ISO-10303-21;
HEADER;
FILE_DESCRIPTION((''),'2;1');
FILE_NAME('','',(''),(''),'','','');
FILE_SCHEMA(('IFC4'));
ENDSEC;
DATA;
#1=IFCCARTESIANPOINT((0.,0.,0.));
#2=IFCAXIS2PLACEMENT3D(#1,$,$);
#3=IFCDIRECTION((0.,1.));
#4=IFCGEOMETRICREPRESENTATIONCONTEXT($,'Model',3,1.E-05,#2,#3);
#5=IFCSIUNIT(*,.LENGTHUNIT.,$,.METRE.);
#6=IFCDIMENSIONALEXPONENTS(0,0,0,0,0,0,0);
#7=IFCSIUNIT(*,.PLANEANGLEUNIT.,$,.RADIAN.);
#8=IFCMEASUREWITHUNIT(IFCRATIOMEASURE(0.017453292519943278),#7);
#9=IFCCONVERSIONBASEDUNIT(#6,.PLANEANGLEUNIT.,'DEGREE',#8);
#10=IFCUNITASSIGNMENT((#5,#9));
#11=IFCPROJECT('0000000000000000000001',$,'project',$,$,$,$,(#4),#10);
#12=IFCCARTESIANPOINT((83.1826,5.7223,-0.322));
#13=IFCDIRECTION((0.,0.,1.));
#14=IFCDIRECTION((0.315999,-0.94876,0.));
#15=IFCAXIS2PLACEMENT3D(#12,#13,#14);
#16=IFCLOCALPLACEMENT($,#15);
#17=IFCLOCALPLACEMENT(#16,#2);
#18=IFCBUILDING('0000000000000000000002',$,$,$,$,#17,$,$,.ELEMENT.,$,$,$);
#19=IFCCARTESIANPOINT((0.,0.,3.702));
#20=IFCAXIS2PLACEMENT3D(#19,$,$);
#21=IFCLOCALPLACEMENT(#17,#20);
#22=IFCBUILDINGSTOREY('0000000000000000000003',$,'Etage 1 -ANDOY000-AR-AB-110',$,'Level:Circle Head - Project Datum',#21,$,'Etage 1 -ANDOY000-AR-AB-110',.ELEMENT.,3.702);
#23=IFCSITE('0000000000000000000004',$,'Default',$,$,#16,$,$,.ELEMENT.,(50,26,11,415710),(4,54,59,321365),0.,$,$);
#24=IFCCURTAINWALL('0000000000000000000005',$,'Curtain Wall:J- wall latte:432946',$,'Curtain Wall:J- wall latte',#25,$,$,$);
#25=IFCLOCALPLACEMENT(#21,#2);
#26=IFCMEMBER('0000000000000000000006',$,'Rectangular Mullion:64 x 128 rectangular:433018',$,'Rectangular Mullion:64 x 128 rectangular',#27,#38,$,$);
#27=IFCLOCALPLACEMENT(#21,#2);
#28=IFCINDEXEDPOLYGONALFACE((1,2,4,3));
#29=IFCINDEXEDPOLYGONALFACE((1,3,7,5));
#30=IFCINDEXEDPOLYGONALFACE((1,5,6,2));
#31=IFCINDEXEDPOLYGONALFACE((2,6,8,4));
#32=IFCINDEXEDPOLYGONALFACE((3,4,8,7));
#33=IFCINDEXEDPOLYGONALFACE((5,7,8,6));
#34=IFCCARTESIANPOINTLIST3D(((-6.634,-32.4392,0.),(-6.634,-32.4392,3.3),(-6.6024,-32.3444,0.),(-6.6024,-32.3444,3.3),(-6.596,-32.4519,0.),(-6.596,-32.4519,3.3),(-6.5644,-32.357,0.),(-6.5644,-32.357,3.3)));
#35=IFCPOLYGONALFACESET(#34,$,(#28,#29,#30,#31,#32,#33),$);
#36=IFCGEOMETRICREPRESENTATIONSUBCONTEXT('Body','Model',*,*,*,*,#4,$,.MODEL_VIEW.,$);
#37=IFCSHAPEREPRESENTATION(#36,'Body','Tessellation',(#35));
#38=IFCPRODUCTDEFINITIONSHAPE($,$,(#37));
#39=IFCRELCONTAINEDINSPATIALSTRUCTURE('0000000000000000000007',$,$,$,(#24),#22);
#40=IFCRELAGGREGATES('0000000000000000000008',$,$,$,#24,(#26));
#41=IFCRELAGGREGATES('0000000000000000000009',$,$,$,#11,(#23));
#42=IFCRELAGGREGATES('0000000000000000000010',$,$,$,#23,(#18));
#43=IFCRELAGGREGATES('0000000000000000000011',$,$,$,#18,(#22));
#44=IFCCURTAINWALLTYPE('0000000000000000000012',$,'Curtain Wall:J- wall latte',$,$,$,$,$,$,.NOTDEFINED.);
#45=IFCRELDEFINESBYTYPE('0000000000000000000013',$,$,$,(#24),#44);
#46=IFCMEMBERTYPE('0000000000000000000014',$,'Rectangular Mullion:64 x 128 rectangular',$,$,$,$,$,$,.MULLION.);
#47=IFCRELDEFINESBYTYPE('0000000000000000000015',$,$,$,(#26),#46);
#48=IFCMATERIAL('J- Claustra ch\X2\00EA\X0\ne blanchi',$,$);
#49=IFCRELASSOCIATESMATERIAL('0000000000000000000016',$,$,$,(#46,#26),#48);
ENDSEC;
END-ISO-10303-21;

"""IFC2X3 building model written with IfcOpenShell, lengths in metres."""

from ifc_helpers import new_model, entity, si_unit, converted_unit, direction, frame, origin, origin_2d_with_axis, place, context, subcontext, project, spatial, rectangle, extrude, source, transform, mapped, material, type_object, type_shapes, element, aggregate, save


model = new_model("IFC2X3")

# Units and contexts
model_context = context("Model", 3, precision=1e-05, world=origin(), true_north=direction((0.0, 1.0)))
body_context = subcontext(model_context, "Body", "Model", "MODEL_VIEW")
ifc_project = project(units=[si_unit("LENGTHUNIT", "METRE"), converted_unit("PLANEANGLEUNIT", "DEGREE", entity("IfcRatioMeasure", 0.017453292519943278), si_unit("PLANEANGLEUNIT", "RADIAN"), dimensions=[0, 0, 0, 0, 0, 0, 0])], contexts=[model_context])

# Site, building, storey
site_placement = place(None, frame((83.1826, 5.7223, -0.322), z_axis=(0.0, 0.0, 1.0), x_axis=(0.315999, -0.94876, 0.0)))
site = spatial("IfcSite", under=ifc_project, at=site_placement, Name="Default", CompositionType="ELEMENT", RefLatitude=(50, 26, 11, 415710), RefLongitude=(4, 54, 59, 321365), RefElevation=0.0)
building_placement = place(site_placement, origin())
building = spatial("IfcBuilding", under=site, at=building_placement, CompositionType="ELEMENT")
storey_placement = place(building_placement, frame((0.0, 0.0, 3.702)))
storey = spatial("IfcBuildingStorey", under=building, at=storey_placement, Name="Etage 1 -ANDOY000-AR-AB-110", ObjectType="Level:Circle Head - Project Datum", LongName="Etage 1 -ANDOY000-AR-AB-110", CompositionType="ELEMENT", Elevation=3.702)

# Curtain wall, member
curtain_wall_type = type_object("IfcCurtainWallType", Name="Curtain Wall:J- wall latte", PredefinedType="NOTDEFINED")
ifc_material_1 = material(Name="J- Claustra chêne blanchi")
curtain_wall_1_placement = place(storey_placement, frame((0.0, 0.0, -3.702)))
curtain_wall_1 = element("IfcCurtainWall", 1, at=curtain_wall_1_placement, inside=storey, type_object=curtain_wall_type, Name="Curtain Wall:J- wall latte:432946", ObjectType="Curtain Wall:J- wall latte")
member_type_1 = type_object("IfcMemberType", Name="Rectangular Mullion:64 x 128 rectangular", PredefinedType="MULLION", material=ifc_material_1)
shared_shape_1 = source(origin(), body_context, "Body", "SweptSolid", [
    extrude(rectangle(XDim=0.1, YDim=0.04, at=origin_2d_with_axis()), frame((0.0, 0.0, -3.3), z_axis=(0.0, 0.0, 1.0), x_axis=(0.0, -1.0, 0.0)), (0.0, 0.0, 1.0), 3.3),
])
type_shapes(member_type_1, [shared_shape_1])
member_1_placement = place(curtain_wall_1_placement, frame((-6.5992, -32.3981, 3.702), z_axis=(0.0, 0.0, -1.0), x_axis=(0.948759, -0.316, 0.0)))
member_1 = element("IfcMember", 2, at=member_1_placement, type_object=member_type_1, material=ifc_material_1, Name="Rectangular Mullion:64 x 128 rectangular:433018", ObjectType="Rectangular Mullion:64 x 128 rectangular", context=body_context, shape_type="MappedRepresentation", body=[
    mapped(shared_shape_1, transform((0.0, 0.0, 0.0), scale=1.0)),
])

aggregate(curtain_wall_1, [member_1])

save(model, "model.ifc")
